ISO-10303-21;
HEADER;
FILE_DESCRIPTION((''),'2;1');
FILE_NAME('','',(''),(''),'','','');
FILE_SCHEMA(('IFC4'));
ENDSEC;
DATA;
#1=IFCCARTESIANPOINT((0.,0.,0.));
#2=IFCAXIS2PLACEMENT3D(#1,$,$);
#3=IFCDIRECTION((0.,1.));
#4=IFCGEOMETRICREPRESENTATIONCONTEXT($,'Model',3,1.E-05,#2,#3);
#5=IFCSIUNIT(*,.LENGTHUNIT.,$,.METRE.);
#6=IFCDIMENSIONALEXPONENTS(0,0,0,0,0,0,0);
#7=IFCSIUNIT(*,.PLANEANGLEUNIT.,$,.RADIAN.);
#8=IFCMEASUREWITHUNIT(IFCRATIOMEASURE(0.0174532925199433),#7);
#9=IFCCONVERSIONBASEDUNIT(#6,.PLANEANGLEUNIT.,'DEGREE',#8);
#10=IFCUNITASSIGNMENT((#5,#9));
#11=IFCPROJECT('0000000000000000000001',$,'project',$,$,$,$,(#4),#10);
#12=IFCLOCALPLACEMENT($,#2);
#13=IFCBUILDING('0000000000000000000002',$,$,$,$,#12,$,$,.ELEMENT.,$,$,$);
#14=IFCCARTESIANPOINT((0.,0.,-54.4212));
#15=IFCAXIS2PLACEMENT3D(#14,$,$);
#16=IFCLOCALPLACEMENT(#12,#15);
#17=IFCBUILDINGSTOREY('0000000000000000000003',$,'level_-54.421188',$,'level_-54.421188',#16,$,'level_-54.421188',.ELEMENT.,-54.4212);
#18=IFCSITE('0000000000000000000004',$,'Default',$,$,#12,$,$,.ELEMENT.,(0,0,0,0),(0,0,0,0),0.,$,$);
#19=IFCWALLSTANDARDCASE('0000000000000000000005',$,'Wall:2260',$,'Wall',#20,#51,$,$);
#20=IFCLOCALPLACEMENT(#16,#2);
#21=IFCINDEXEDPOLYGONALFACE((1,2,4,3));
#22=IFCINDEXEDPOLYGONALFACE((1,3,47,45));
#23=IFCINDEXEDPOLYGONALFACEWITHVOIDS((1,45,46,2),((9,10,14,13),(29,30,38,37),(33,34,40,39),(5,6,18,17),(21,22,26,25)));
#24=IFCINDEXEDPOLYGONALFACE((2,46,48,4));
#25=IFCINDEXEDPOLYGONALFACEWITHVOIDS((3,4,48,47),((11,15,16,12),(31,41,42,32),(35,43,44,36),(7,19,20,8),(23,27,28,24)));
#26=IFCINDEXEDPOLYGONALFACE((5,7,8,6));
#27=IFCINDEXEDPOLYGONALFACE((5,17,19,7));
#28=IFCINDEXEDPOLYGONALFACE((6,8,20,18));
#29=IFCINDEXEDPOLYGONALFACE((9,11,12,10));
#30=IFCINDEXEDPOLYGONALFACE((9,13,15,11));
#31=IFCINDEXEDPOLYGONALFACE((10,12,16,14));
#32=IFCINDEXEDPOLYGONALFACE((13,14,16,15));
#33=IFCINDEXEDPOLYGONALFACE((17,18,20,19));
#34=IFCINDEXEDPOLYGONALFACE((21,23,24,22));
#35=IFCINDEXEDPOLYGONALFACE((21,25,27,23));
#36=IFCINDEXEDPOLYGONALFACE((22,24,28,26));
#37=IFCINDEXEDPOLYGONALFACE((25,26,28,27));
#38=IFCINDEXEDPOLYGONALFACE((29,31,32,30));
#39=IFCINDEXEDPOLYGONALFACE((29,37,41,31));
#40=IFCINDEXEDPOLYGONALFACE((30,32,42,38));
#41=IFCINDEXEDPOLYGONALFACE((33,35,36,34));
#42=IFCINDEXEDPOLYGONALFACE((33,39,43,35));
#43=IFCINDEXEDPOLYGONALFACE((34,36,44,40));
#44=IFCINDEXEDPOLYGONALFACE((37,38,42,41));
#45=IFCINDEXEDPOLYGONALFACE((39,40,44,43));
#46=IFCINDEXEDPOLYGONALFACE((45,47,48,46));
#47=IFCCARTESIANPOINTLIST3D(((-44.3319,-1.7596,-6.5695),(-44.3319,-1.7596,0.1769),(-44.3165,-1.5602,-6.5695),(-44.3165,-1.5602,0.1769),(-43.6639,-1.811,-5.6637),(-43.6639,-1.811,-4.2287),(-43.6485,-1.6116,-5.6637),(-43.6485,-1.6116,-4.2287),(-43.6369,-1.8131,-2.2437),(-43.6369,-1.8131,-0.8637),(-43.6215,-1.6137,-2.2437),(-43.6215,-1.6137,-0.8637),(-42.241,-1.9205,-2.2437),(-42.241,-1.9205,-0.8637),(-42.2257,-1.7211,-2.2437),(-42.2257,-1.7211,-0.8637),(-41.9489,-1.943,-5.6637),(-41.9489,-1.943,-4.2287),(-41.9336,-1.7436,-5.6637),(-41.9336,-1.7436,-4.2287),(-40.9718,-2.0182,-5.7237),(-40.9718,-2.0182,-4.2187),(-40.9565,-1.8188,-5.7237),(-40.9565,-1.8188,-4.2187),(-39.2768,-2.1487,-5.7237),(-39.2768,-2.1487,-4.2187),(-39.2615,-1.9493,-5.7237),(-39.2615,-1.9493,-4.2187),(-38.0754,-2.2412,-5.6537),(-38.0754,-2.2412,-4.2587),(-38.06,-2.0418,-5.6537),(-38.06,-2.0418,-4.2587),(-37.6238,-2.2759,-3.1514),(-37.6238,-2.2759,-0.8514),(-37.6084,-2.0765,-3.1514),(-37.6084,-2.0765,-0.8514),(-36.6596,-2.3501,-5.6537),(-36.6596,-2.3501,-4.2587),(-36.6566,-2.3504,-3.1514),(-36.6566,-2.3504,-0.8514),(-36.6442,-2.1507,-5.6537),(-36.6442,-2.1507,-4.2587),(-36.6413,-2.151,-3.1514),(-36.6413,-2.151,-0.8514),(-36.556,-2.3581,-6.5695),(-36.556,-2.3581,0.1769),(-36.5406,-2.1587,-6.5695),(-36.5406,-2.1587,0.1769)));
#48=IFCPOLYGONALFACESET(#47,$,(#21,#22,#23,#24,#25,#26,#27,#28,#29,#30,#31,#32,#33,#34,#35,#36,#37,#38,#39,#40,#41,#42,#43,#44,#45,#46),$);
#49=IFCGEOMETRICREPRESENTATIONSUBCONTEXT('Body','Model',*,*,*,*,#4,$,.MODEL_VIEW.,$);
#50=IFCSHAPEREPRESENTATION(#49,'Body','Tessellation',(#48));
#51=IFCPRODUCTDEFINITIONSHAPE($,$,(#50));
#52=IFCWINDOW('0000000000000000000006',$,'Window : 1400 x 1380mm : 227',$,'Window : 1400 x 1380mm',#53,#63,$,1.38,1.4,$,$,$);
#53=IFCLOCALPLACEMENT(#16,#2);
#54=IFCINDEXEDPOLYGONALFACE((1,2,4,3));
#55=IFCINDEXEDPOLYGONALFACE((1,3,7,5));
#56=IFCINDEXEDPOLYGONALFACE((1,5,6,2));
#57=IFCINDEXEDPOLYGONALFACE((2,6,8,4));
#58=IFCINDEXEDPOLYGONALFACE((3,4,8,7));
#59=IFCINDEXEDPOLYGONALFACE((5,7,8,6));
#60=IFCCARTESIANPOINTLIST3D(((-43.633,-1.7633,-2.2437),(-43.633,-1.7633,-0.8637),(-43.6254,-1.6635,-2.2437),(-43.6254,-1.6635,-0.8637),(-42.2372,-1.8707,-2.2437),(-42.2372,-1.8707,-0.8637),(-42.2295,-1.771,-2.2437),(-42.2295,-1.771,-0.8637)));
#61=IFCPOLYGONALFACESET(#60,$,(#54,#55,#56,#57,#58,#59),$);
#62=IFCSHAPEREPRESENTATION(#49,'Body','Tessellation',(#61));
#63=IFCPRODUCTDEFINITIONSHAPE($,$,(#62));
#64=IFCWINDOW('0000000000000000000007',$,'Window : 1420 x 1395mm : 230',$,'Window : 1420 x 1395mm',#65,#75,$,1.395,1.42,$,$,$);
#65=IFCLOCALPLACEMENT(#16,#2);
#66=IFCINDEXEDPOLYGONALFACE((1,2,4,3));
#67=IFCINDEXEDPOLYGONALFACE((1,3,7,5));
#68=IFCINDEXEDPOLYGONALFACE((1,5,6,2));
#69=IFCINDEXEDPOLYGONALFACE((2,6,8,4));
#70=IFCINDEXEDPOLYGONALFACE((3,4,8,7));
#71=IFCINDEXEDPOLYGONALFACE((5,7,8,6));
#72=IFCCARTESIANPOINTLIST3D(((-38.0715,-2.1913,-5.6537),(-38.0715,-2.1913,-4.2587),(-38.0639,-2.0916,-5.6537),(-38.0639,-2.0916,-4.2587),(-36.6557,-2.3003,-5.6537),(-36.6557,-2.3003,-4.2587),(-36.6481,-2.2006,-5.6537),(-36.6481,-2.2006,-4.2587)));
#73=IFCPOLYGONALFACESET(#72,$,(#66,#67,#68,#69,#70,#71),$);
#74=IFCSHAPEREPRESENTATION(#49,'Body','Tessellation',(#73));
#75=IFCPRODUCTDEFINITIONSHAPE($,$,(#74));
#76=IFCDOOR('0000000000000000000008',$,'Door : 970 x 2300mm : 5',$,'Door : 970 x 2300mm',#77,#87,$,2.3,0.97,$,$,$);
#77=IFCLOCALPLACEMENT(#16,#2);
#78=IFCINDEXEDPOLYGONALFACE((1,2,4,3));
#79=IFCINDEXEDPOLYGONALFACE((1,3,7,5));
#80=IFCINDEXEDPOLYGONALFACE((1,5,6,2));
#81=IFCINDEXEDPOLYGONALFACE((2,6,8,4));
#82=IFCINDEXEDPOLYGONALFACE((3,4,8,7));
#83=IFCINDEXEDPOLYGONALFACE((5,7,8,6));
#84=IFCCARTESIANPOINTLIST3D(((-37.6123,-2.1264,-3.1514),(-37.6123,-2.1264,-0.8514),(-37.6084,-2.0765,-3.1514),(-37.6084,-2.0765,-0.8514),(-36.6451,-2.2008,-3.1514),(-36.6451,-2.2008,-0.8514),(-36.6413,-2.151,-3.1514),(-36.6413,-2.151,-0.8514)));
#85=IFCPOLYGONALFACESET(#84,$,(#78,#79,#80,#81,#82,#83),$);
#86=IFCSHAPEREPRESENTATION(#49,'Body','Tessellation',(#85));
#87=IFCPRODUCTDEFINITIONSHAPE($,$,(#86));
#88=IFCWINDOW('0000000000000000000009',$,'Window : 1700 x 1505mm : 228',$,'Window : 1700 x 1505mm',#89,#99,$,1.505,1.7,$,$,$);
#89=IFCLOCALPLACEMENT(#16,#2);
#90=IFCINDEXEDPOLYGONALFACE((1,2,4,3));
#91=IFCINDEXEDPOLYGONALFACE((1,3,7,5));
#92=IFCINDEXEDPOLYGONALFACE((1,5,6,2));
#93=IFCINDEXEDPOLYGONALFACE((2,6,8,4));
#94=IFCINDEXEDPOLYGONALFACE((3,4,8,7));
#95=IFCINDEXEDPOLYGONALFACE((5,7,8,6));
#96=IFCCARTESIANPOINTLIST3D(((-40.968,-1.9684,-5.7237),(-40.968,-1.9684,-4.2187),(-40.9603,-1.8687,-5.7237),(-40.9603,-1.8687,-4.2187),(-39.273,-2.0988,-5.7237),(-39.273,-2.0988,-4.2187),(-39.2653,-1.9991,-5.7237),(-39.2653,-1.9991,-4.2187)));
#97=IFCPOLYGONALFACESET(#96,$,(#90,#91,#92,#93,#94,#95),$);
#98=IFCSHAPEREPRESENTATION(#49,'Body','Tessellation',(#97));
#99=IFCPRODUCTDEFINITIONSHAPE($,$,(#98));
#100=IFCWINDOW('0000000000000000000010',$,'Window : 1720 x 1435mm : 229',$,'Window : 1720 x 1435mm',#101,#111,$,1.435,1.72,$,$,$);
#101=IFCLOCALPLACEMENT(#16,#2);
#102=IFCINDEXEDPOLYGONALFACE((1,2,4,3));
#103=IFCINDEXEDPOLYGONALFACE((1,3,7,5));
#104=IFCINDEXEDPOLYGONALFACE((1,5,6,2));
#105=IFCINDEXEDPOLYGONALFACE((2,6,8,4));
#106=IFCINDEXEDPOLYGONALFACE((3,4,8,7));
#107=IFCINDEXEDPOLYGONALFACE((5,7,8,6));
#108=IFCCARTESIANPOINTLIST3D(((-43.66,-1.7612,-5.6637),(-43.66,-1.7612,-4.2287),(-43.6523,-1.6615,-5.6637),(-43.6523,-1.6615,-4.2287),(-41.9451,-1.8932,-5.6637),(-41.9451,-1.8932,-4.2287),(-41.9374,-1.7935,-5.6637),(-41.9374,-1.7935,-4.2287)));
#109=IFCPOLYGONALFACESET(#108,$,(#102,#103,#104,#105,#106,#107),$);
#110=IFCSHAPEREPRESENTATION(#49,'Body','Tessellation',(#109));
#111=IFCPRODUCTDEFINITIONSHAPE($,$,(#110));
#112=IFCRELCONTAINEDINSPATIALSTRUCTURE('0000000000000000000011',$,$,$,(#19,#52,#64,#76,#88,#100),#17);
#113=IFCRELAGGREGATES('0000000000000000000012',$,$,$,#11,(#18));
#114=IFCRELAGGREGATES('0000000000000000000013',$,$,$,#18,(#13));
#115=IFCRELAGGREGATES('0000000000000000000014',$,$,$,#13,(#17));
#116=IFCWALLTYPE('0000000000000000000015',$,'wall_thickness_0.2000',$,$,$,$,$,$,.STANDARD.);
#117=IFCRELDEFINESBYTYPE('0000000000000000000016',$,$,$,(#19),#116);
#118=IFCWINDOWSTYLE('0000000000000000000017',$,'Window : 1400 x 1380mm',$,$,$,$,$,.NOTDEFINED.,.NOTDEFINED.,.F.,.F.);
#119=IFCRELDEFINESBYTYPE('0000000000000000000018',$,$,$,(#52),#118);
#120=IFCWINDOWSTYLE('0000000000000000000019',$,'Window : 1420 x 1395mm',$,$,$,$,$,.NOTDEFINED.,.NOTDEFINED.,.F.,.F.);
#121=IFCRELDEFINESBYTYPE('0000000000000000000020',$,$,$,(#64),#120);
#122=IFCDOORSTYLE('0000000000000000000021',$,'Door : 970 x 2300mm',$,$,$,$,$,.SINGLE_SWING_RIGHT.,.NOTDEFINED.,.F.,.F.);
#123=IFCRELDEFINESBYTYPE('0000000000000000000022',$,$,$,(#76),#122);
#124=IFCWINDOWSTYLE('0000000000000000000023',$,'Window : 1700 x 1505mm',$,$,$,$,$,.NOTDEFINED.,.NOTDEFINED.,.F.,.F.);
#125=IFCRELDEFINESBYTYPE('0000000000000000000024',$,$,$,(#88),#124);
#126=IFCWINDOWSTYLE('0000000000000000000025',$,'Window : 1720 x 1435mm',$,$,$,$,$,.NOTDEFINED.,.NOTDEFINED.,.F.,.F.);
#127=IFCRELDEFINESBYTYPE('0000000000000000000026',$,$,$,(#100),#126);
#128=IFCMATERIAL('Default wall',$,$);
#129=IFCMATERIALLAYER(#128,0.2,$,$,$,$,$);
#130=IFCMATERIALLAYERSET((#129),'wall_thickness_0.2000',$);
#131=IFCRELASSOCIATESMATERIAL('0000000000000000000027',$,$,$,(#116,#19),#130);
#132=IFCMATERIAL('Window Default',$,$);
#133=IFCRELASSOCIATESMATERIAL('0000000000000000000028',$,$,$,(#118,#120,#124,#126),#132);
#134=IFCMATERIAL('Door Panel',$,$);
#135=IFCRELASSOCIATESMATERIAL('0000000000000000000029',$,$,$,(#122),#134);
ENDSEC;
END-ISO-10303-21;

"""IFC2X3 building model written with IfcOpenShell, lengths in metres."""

from ifc_helpers import new_model, entity, si_unit, converted_unit, direction, frame, frame_2d, origin, origin_2d_with_axis, place, context, subcontext, project, spatial, polyline, rectangle, outline, extrude, source, transform, mapped, material, layer, layer_set, layer_usage, type_object, type_shapes, element, fill, save


model = new_model("IFC2X3")

# Units and contexts
model_context = context("Model", 3, precision=1e-05, world=origin(), true_north=direction((0.0, 1.0)))
body_context = subcontext(model_context, "Body", "Model", "MODEL_VIEW")
ifc_project = project(units=[si_unit("LENGTHUNIT", "METRE"), converted_unit("PLANEANGLEUNIT", "DEGREE", entity("IfcRatioMeasure", 0.0174532925199433), si_unit("PLANEANGLEUNIT", "RADIAN"), dimensions=[0, 0, 0, 0, 0, 0, 0])], contexts=[model_context])

# Site, building, storey
placement_1 = place(None, origin())
site = spatial("IfcSite", under=ifc_project, at=placement_1, Name="Default", CompositionType="ELEMENT", RefLatitude=(0, 0, 0, 0), RefLongitude=(0, 0, 0, 0), RefElevation=0.0)
building = spatial("IfcBuilding", under=site, at=placement_1, CompositionType="ELEMENT")
storey_placement = place(placement_1, frame((0.0, 0.0, -54.4212)))
storey = spatial("IfcBuildingStorey", under=building, at=storey_placement, Name="level_-54.421188", ObjectType="level_-54.421188", LongName="level_-54.421188", CompositionType="ELEMENT", Elevation=-54.4212)

# Shared definitions
ifc_material_1 = material(Name="Default wall")
ifc_layer = layer(ifc_material_1, 0.2)
ifc_layer_set = layer_set([ifc_layer], Name="wall_thickness_0.2000")
ifc_layer_usage = layer_usage(ifc_layer_set, "AXIS2", "POSITIVE", -0.1)
wall_type = type_object("IfcWallType", Name="wall_thickness_0.2000", PredefinedType="STANDARD", material=ifc_layer_set)

# Shared definitions
ifc_material_2 = material(Name="Window Default")

# Wall, openings, windows, door
placement_2 = place(placement_1, frame((0.0, 0.0, -60.9907)))
wall_1_placement = place(placement_2, frame((-44.3242, -1.6599, 0.0), z_axis=(0.0, 0.0, 1.0), x_axis=(0.997051, -0.076741, 0.0)))
wall_1 = element("IfcWallStandardCase", 1, at=wall_1_placement, inside=storey, type_object=wall_type, material=ifc_layer_usage, Name="Wall:2260", ObjectType="Wall", context=body_context, shape_type="SweptSolid", body=[
    extrude(outline(polyline([(7.7989, -0.1), (7.7989, 0.1), (0.0, 0.1), (0.0, -0.1), (7.7989, -0.1)])), origin(), (0.0, 0.0, 1.0), 6.7464),
])
opening_1_placement = place(wall_1_placement, frame((6.7279, -0.1, 3.418)))
opening_1 = element("IfcOpeningElement", 2, at=opening_1_placement, cuts=wall_1, ObjectType="Opening", context=body_context, shape_type="SweptSolid", body=[
    extrude(rectangle(XDim=0.97, YDim=2.3, at=frame_2d((1.15, 0.485), x_axis=(0.0, 1.0))), frame((0.0, 0.0, 0.0), z_axis=(0.0, 1.0, 0.0), x_axis=(0.0, 0.0, 1.0)), (0.0, 0.0, 1.0), 0.2),
])
opening_2_placement = place(wall_1_placement, frame((0.6971, -0.1, 4.3257)))
opening_2 = element("IfcOpeningElement", 3, at=opening_2_placement, cuts=wall_1, ObjectType="Opening", context=body_context, shape_type="SweptSolid", body=[
    extrude(rectangle(XDim=1.4, YDim=1.38, at=frame_2d((0.69, 0.7), x_axis=(0.0, 1.0))), frame((0.0, 0.0, 0.0), z_axis=(0.0, 1.0, 0.0), x_axis=(0.0, 0.0, 1.0)), (0.0, 0.0, 1.0), 0.2),
])
opening_3_placement = place(wall_1_placement, frame((3.37, -0.1, 0.8457)))
opening_3 = element("IfcOpeningElement", 4, at=opening_3_placement, cuts=wall_1, ObjectType="Opening", context=body_context, shape_type="SweptSolid", body=[
    extrude(rectangle(XDim=1.7, YDim=1.505, at=frame_2d((0.7525, 0.85), x_axis=(0.0, 1.0))), frame((0.0, 0.0, 0.0), z_axis=(0.0, 1.0, 0.0), x_axis=(0.0, 0.0, 1.0)), (0.0, 0.0, 1.0), 0.2),
])
opening_4_placement = place(wall_1_placement, frame((0.67, -0.1, 0.9058)))
opening_4 = element("IfcOpeningElement", 5, at=opening_4_placement, cuts=wall_1, ObjectType="Opening", context=body_context, shape_type="SweptSolid", body=[
    extrude(rectangle(XDim=1.72, YDim=1.435, at=frame_2d((0.7175, 0.86), x_axis=(0.0, 1.0))), frame((0.0, 0.0, 0.0), z_axis=(0.0, 1.0, 0.0), x_axis=(0.0, 0.0, 1.0)), (0.0, 0.0, 1.0), 0.2),
])
opening_5_placement = place(wall_1_placement, frame((6.275, -0.1, 0.9157)))
opening_5 = element("IfcOpeningElement", 6, at=opening_5_placement, cuts=wall_1, ObjectType="Opening", context=body_context, shape_type="SweptSolid", body=[
    extrude(rectangle(XDim=1.42, YDim=1.395, at=frame_2d((0.6975, 0.71), x_axis=(0.0, 1.0))), frame((0.0, 0.0, 0.0), z_axis=(0.0, 1.0, 0.0), x_axis=(0.0, 0.0, 1.0)), (0.0, 0.0, 1.0), 0.2),
])
window_style_1 = type_object("IfcWindowStyle", Name="Window : 1400 x 1380mm", ConstructionType="NOTDEFINED", OperationType="NOTDEFINED", ParameterTakesPrecedence=False, Sizeable=False, material=ifc_material_2)
shared_shape_1 = source(origin(), body_context, "Body", "SweptSolid", [
    extrude(rectangle(XDim=0.1, YDim=1.4, at=origin_2d_with_axis()), frame((0.7, 0.1, 0.0), z_axis=(0.0, 0.0, 1.0), x_axis=(0.0, 1.0, 0.0)), (0.0, 0.0, 1.0), 1.38),
])
type_shapes(window_style_1, [shared_shape_1])
window_1_placement = place(opening_2_placement, origin())
window_1 = element("IfcWindow", 7, at=window_1_placement, inside=storey, type_object=window_style_1, Name="Window : 1400 x 1380mm : 227", ObjectType="Window : 1400 x 1380mm", OverallHeight=1.38, OverallWidth=1.4, context=body_context, shape_type="MappedRepresentation", body=[
    mapped(shared_shape_1, transform((0.0, 0.0, 0.0), scale=1.0)),
])
fill(opening_2, window_1)
window_style_2 = type_object("IfcWindowStyle", Name="Window : 1420 x 1395mm", ConstructionType="NOTDEFINED", OperationType="NOTDEFINED", ParameterTakesPrecedence=False, Sizeable=False, material=ifc_material_2)
shared_shape_2 = source(origin(), body_context, "Body", "SweptSolid", [
    extrude(rectangle(XDim=0.1, YDim=1.42, at=origin_2d_with_axis()), frame((0.71, 0.1, 0.0), z_axis=(0.0, 0.0, 1.0), x_axis=(0.0, 1.0, 0.0)), (0.0, 0.0, 1.0), 1.395),
])
type_shapes(window_style_2, [shared_shape_2])
window_2_placement = place(opening_5_placement, origin())
window_2 = element("IfcWindow", 8, at=window_2_placement, inside=storey, type_object=window_style_2, Name="Window : 1420 x 1395mm : 230", ObjectType="Window : 1420 x 1395mm", OverallHeight=1.395, OverallWidth=1.42, context=body_context, shape_type="MappedRepresentation", body=[
    mapped(shared_shape_2, transform((0.0, 0.0, 0.0), scale=1.0)),
])
fill(opening_5, window_2)
ifc_material_3 = material(Name="Door Panel")
door_style = type_object("IfcDoorStyle", Name="Door : 970 x 2300mm", ConstructionType="NOTDEFINED", OperationType="SINGLE_SWING_RIGHT", ParameterTakesPrecedence=False, Sizeable=False, material=ifc_material_3)
shared_shape_3 = source(origin(), body_context, "Body", "SweptSolid", [
    extrude(rectangle(XDim=0.05, YDim=0.97, at=origin_2d_with_axis()), frame((0.485, 0.175, 0.0), z_axis=(0.0, 0.0, 1.0), x_axis=(0.0, 1.0, 0.0)), (0.0, 0.0, 1.0), 2.3),
])
type_shapes(door_style, [shared_shape_3])
door_placement = place(opening_1_placement, origin())
door = element("IfcDoor", 9, at=door_placement, inside=storey, type_object=door_style, Name="Door : 970 x 2300mm : 5", ObjectType="Door : 970 x 2300mm", OverallHeight=2.3, OverallWidth=0.97, context=body_context, shape_type="MappedRepresentation", body=[
    mapped(shared_shape_3, transform((0.0, 0.0, 0.0), scale=1.0)),
])
fill(opening_1, door)
window_style_3 = type_object("IfcWindowStyle", Name="Window : 1700 x 1505mm", ConstructionType="NOTDEFINED", OperationType="NOTDEFINED", ParameterTakesPrecedence=False, Sizeable=False, material=ifc_material_2)
shared_shape_4 = source(origin(), body_context, "Body", "SweptSolid", [
    extrude(rectangle(XDim=0.1, YDim=1.7, at=origin_2d_with_axis()), frame((0.85, 0.1, 0.0), z_axis=(0.0, 0.0, 1.0), x_axis=(0.0, 1.0, 0.0)), (0.0, 0.0, 1.0), 1.505),
])
type_shapes(window_style_3, [shared_shape_4])
window_3_placement = place(opening_3_placement, origin())
window_3 = element("IfcWindow", 10, at=window_3_placement, inside=storey, type_object=window_style_3, Name="Window : 1700 x 1505mm : 228", ObjectType="Window : 1700 x 1505mm", OverallHeight=1.505, OverallWidth=1.7, context=body_context, shape_type="MappedRepresentation", body=[
    mapped(shared_shape_4, transform((0.0, 0.0, 0.0), scale=1.0)),
])
fill(opening_3, window_3)
window_style_4 = type_object("IfcWindowStyle", Name="Window : 1720 x 1435mm", ConstructionType="NOTDEFINED", OperationType="NOTDEFINED", ParameterTakesPrecedence=False, Sizeable=False, material=ifc_material_2)
shared_shape_5 = source(origin(), body_context, "Body", "SweptSolid", [
    extrude(rectangle(XDim=0.1, YDim=1.72, at=origin_2d_with_axis()), frame((0.86, 0.1, 0.0), z_axis=(0.0, 0.0, 1.0), x_axis=(0.0, 1.0, 0.0)), (0.0, 0.0, 1.0), 1.435),
])
type_shapes(window_style_4, [shared_shape_5])
window_4_placement = place(opening_4_placement, origin())
window_4 = element("IfcWindow", 11, at=window_4_placement, inside=storey, type_object=window_style_4, Name="Window : 1720 x 1435mm : 229", ObjectType="Window : 1720 x 1435mm", OverallHeight=1.435, OverallWidth=1.72, context=body_context, shape_type="MappedRepresentation", body=[
    mapped(shared_shape_5, transform((0.0, 0.0, 0.0), scale=1.0)),
])
fill(opening_4, window_4)

save(model, "model.ifc")
